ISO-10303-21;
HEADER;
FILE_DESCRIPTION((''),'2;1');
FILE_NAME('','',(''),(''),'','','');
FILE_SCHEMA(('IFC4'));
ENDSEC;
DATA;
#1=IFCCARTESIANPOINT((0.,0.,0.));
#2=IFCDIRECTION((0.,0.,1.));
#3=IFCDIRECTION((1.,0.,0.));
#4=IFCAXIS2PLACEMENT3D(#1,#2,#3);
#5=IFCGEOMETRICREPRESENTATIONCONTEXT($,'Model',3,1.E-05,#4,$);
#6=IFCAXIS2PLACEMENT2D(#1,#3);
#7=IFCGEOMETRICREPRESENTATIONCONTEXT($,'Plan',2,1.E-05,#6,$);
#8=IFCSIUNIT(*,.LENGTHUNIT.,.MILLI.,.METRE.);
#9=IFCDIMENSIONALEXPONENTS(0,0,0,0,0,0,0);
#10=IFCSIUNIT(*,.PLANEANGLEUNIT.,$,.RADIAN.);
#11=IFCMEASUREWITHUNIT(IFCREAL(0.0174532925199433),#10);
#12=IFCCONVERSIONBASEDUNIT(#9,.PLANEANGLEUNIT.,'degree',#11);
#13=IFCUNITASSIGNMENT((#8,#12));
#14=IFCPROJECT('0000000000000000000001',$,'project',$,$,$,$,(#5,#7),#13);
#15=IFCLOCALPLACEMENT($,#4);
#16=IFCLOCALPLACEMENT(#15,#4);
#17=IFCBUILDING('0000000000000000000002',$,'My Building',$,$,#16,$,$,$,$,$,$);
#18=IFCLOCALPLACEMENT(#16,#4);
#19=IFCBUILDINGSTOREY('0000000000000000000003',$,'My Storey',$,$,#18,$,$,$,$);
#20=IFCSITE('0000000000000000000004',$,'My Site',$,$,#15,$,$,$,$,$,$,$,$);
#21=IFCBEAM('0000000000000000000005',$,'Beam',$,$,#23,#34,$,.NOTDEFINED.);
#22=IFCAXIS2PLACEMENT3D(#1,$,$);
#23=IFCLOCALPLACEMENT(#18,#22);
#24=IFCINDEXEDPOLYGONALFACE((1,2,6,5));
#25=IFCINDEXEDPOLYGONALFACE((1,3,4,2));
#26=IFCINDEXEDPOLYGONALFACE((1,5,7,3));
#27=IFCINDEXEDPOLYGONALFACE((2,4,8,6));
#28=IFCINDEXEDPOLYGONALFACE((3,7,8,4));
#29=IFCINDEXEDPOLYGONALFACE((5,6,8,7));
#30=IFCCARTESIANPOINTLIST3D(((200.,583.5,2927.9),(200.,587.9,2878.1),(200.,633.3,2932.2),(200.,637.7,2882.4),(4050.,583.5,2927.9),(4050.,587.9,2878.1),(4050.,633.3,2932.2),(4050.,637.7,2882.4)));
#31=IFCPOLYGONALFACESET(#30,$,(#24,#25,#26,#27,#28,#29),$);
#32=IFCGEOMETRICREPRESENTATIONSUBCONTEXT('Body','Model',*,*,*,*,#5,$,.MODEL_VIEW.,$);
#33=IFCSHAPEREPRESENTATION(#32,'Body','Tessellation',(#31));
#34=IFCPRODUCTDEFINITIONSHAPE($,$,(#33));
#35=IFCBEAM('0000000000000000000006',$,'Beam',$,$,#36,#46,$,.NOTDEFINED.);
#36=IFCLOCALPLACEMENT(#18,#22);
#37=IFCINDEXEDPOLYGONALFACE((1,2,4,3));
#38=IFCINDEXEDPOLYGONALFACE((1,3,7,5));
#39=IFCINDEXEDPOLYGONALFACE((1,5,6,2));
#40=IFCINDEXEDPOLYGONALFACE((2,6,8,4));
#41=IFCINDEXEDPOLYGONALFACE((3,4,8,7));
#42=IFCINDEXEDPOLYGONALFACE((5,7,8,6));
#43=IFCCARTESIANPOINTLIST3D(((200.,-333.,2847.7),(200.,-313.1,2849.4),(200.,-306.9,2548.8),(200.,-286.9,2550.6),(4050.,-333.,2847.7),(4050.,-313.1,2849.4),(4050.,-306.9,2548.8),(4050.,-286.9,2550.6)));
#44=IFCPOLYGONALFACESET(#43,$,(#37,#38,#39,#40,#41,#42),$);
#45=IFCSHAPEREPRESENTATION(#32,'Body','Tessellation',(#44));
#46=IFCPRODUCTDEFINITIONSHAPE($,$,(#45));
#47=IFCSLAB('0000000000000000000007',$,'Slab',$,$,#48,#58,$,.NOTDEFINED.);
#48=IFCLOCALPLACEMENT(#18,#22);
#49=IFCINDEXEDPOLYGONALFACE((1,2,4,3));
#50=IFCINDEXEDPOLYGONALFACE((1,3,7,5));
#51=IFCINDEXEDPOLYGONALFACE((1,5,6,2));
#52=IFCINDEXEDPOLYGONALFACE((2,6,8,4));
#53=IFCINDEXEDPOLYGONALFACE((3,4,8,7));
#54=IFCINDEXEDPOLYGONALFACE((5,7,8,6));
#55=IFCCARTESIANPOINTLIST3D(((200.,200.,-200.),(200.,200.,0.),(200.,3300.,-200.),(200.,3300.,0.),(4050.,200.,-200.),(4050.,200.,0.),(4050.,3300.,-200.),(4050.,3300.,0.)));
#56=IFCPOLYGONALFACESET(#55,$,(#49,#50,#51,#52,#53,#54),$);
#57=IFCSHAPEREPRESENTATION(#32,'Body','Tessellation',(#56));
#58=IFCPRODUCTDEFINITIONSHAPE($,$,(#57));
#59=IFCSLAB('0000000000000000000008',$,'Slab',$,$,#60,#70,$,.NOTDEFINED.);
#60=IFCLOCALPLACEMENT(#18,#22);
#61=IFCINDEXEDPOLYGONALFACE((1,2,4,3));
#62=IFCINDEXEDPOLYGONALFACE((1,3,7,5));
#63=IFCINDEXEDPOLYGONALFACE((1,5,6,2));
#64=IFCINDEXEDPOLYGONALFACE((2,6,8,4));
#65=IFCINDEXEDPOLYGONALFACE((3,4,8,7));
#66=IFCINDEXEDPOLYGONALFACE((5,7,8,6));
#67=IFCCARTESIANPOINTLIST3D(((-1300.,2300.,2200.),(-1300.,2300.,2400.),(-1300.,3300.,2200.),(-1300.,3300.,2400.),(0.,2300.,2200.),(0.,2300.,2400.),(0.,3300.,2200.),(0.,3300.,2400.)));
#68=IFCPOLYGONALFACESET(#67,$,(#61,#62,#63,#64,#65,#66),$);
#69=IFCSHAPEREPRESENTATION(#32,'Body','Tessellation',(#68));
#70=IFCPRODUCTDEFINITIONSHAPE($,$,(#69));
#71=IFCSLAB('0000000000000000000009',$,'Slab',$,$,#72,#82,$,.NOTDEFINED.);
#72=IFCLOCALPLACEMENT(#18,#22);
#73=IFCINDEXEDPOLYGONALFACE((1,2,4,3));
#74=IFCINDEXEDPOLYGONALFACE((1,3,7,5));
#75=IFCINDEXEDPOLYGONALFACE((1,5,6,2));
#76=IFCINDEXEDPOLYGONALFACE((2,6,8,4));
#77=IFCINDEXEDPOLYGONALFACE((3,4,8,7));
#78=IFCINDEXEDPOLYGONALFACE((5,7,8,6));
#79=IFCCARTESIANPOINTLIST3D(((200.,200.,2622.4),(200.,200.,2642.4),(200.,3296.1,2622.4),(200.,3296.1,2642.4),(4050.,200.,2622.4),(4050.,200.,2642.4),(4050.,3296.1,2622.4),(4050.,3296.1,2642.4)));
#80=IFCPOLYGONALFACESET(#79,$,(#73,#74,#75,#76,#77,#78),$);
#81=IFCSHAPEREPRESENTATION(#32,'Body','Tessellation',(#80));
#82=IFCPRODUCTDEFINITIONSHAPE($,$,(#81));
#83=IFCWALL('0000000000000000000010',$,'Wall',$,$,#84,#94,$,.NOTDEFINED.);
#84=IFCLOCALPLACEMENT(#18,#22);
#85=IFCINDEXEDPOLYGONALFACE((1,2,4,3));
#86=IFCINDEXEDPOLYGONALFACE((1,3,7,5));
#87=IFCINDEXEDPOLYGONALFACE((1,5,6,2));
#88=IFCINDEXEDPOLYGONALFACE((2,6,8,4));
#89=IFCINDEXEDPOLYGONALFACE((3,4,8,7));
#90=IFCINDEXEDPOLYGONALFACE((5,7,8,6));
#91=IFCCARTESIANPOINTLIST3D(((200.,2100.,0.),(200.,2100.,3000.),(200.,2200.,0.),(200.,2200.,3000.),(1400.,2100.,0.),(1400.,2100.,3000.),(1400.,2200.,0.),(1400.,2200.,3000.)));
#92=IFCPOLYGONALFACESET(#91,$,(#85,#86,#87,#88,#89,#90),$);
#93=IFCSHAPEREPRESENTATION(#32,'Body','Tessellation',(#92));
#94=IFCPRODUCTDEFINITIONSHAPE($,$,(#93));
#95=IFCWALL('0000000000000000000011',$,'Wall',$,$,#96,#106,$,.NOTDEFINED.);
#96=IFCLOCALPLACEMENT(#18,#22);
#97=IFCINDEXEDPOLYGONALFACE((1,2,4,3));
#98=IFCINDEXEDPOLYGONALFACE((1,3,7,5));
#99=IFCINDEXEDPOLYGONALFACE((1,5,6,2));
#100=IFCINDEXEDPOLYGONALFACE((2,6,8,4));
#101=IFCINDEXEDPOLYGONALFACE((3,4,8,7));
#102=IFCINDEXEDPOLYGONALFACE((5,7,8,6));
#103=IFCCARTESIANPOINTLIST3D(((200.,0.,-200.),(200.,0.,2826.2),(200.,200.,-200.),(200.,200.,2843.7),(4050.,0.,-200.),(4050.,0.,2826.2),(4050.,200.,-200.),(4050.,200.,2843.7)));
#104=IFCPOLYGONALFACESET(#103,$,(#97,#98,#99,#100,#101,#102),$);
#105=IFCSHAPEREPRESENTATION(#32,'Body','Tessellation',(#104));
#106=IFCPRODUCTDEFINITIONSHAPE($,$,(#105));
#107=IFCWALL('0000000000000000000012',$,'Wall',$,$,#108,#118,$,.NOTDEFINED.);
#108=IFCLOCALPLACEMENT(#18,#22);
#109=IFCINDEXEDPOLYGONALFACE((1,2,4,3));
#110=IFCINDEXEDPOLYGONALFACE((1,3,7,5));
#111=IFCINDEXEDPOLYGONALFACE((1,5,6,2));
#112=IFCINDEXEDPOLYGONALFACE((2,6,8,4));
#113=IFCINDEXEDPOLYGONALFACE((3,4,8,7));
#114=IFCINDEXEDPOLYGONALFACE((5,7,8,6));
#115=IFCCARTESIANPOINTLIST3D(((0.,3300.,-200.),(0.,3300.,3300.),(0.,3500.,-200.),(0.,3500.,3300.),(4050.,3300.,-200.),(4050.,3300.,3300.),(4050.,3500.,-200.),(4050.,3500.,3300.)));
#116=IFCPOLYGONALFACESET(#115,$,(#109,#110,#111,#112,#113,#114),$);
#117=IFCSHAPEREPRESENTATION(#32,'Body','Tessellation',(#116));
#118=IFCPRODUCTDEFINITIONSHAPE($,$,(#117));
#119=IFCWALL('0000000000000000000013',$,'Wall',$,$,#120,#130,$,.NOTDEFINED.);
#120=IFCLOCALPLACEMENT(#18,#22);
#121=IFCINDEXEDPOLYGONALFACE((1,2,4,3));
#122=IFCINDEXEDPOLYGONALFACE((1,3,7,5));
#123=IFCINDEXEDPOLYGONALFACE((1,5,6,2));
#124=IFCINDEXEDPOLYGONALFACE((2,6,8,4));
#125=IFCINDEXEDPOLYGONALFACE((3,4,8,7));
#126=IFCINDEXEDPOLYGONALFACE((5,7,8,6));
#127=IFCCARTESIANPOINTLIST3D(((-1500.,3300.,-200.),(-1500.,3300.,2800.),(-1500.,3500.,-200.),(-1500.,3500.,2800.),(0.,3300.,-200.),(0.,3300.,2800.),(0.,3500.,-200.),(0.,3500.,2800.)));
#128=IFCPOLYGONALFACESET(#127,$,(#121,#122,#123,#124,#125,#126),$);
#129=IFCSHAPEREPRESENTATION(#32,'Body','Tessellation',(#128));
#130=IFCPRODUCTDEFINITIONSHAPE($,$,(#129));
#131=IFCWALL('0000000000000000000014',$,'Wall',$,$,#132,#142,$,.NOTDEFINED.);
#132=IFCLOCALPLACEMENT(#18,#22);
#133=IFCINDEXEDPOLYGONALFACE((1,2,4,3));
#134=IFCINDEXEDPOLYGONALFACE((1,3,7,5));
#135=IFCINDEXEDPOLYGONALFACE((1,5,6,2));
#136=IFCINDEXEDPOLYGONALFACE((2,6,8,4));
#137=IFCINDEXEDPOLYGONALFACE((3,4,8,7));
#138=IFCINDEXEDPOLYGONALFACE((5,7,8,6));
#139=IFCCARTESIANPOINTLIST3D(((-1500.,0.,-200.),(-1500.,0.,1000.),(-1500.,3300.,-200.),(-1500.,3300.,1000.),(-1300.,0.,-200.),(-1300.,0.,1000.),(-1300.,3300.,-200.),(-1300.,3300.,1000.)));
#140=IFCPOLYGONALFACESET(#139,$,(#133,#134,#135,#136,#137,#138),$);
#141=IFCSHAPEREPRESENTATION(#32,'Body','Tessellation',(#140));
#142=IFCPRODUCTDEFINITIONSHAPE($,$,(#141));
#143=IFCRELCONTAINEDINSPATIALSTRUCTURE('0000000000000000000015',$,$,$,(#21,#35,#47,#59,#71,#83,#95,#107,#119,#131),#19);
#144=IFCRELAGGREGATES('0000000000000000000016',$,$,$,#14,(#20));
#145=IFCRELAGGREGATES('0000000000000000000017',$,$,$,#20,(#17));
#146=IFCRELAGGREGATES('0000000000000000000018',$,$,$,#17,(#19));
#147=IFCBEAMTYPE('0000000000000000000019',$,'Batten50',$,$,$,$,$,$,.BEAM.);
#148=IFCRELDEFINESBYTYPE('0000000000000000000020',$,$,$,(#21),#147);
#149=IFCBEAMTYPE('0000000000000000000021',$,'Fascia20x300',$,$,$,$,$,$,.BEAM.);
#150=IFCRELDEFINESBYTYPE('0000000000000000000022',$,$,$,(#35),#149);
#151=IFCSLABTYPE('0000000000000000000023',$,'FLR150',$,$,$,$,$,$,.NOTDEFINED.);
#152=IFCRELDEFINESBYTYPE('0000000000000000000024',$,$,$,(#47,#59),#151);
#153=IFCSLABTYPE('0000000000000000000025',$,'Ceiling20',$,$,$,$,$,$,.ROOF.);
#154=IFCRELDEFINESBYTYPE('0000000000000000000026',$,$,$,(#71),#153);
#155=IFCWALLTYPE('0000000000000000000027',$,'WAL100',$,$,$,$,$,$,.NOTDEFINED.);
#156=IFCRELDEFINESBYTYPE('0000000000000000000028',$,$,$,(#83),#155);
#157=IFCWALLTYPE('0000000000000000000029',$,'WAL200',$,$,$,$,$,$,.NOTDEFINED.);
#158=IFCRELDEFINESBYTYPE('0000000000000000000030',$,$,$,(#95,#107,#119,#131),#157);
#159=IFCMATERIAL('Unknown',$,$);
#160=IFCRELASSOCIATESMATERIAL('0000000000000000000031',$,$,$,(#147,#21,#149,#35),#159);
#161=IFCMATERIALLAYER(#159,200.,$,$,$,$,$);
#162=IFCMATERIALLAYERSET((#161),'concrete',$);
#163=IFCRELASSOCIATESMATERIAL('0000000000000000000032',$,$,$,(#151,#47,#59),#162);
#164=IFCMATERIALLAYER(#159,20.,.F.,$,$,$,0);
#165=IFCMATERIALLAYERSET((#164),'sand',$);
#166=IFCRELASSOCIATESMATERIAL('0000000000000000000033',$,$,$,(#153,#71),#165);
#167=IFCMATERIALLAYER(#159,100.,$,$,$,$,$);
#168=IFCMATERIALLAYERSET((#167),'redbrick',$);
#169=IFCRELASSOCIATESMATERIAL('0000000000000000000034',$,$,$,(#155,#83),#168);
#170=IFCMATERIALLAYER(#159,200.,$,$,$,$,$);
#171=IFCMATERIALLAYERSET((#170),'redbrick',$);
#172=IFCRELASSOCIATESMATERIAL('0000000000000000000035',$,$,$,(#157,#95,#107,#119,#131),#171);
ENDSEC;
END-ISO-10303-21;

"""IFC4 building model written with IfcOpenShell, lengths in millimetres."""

from ifc_helpers import new_model, entity, si_unit, converted_unit, frame, frame_2d, origin_with_axes, place, context, subcontext, project, spatial, line, indexed_curve, rectangle, outline, extrude, clip, halfspace, material, layer, layer_set, layer_usage, material_profile, profile_set, profile_usage, type_object, element, save


model = new_model("IFC4")

# Units and contexts
model_context = context("Model", 3, precision=1e-05, world=origin_with_axes())
plan_context = context("Plan", 2, precision=1e-05, world=frame_2d((0.0, 0.0, 0.0), x_axis=(1.0, 0.0, 0.0)))
body_context = subcontext(model_context, "Body", "Model", "MODEL_VIEW")
ifc_project = project(units=[si_unit("LENGTHUNIT", "METRE", prefix="MILLI"), converted_unit("PLANEANGLEUNIT", "degree", entity("IfcReal", 0.0174532925199433), si_unit("PLANEANGLEUNIT", "RADIAN"), dimensions=[0, 0, 0, 0, 0, 0, 0])], contexts=[model_context, plan_context])

# Site, building, storey
site_placement = place(None, origin_with_axes())
site = spatial("IfcSite", under=ifc_project, at=site_placement, Name="My Site")
building_placement = place(site_placement, origin_with_axes())
building = spatial("IfcBuilding", under=site, at=building_placement, Name="My Building")
storey_placement = place(building_placement, origin_with_axes())
storey = spatial("IfcBuildingStorey", under=building, at=storey_placement, Name="My Storey")

# Shared definitions
ifc_material = material(Name="Unknown")

# Beams
ifc_material_profile_1 = material_profile(ifc_material, rectangle(XDim=50.0, YDim=50.0))
ifc_profile_set_1 = profile_set([ifc_material_profile_1], Name="blank")
beam_type_1 = type_object("IfcBeamType", Name="Batten50", PredefinedType="BEAM", material=ifc_profile_set_1)
ifc_profile_usage_1 = profile_usage(ifc_profile_set_1, cardinal=5)
beam_1_placement = place(storey_placement, frame((200.0, 610.6, 2905.1), z_axis=(1.0, 0.0, 0.0), x_axis=(0.0, 0.996195, 0.087156)))
element("IfcBeam", 1, at=beam_1_placement, inside=storey, type_object=beam_type_1, material=ifc_profile_usage_1, Name="Beam", PredefinedType="NOTDEFINED", context=body_context, shape_type="SweptSolid", body=[
    extrude(rectangle(XDim=50.0, YDim=50.0), origin_with_axes(), (0.0, 0.0, 1.0), 3850.0),
])
ifc_material_profile_2 = material_profile(ifc_material, rectangle(XDim=20.0, YDim=300.0))
ifc_profile_set_2 = profile_set([ifc_material_profile_2], Name="sand")
ifc_profile_usage_2 = profile_usage(ifc_profile_set_2, cardinal=5)
beam_type_2 = type_object("IfcBeamType", Name="Fascia20x300", PredefinedType="BEAM", material=ifc_profile_set_2)
beam_2_placement = place(storey_placement, frame((200.0, -310.0, 2699.1), z_axis=(1.0, 0.0, 0.0), x_axis=(0.0, 0.996195, 0.087156)))
element("IfcBeam", 2, at=beam_2_placement, inside=storey, type_object=beam_type_2, material=ifc_profile_usage_2, Name="Beam", PredefinedType="NOTDEFINED", context=body_context, shape_type="SweptSolid", body=[
    extrude(rectangle(XDim=20.0, YDim=300.0), origin_with_axes(), (0.0, 0.0, 1.0), 3850.0),
])

# Slabs
ifc_layer_1 = layer(ifc_material, 200.0)
ifc_layer_set_1 = layer_set([ifc_layer_1], Name="concrete")
ifc_layer_usage_1 = layer_usage(ifc_layer_set_1, "AXIS3", "POSITIVE", 0.0)
slab_type_1 = type_object("IfcSlabType", Name="FLR150", PredefinedType="NOTDEFINED", material=ifc_layer_set_1)
slab_1_placement = place(storey_placement, frame((200.0, 200.0, -200.0), z_axis=(0.0, 0.0, 1.0), x_axis=(1.0, 0.0, 0.0)))
element("IfcSlab", 3, at=slab_1_placement, inside=storey, type_object=slab_type_1, material=ifc_layer_usage_1, Name="Slab", PredefinedType="NOTDEFINED", context=body_context, shape_type="SweptSolid", body=[
    extrude(outline(indexed_curve([(0.0, 0.0), (3850.0, 0.0), (3850.0, 3100.0), (0.0, 3100.0)], segments=[line(3, 2), line(2, 1), line(1, 4), line(4, 3)], self_intersect=False)), None, (0.0, 0.0, 1.0), 200.0),
])
ifc_layer_usage_2 = layer_usage(ifc_layer_set_1, "AXIS3", "POSITIVE", 0.0)
slab_2_placement = place(storey_placement, frame((-1300.0, 2300.0, 2200.0), z_axis=(0.0, 0.0, 1.0), x_axis=(1.0, 0.0, 0.0)))
element("IfcSlab", 4, at=slab_2_placement, inside=storey, type_object=slab_type_1, material=ifc_layer_usage_2, Name="Slab", PredefinedType="NOTDEFINED", context=body_context, shape_type="SweptSolid", body=[
    extrude(outline(indexed_curve([(0.0, 0.0), (1300.0, 0.0), (1300.0, 1000.0), (0.0, 1000.0)], segments=[line(3, 2), line(2, 1), line(1, 4), line(4, 3)], self_intersect=False)), None, (0.0, 0.0, 1.0), 200.0),
])
ifc_layer_2 = layer(ifc_material, 20.0, ventilated=False, Priority=0)
ifc_layer_set_2 = layer_set([ifc_layer_2], Name="sand")
ifc_layer_usage_3 = layer_usage(ifc_layer_set_2, "AXIS3", "POSITIVE", 0.0)
slab_type_2 = type_object("IfcSlabType", Name="Ceiling20", PredefinedType="ROOF", material=ifc_layer_set_2)
slab_3_placement = place(storey_placement, frame((200.0, 200.0, 2622.4), z_axis=(0.0, 0.0, 1.0), x_axis=(1.0, 0.0, 0.0)))
element("IfcSlab", 5, at=slab_3_placement, inside=storey, type_object=slab_type_2, material=ifc_layer_usage_3, Name="Slab", PredefinedType="NOTDEFINED", context=body_context, shape_type="SweptSolid", body=[
    extrude(outline(indexed_curve([(0.0, 0.0), (3850.0, 0.0), (3850.0, 3096.1), (0.0, 3096.1)], segments=[line(3, 2), line(2, 1), line(1, 4), line(4, 3)], self_intersect=False)), None, (0.0, 0.0, 1.0), 20.0),
])

# Walls
ifc_layer_3 = layer(ifc_material, 100.0)
ifc_layer_set_3 = layer_set([ifc_layer_3], Name="redbrick")
ifc_layer_usage_4 = layer_usage(ifc_layer_set_3, "AXIS2", "POSITIVE", 0.0)
wall_type_1 = type_object("IfcWallType", Name="WAL100", PredefinedType="NOTDEFINED", material=ifc_layer_set_3)
wall_1_placement = place(storey_placement, frame((200.0, 2100.0, 0.0), z_axis=(0.0, 0.0, 1.0), x_axis=(1.0, 0.0, 0.0)))
element("IfcWall", 6, at=wall_1_placement, inside=storey, type_object=wall_type_1, material=ifc_layer_usage_4, Name="Wall", PredefinedType="NOTDEFINED", context=body_context, shape_type="SweptSolid", body=[
    extrude(outline(indexed_curve([(0.0, 0.0), (0.0, 100.0), (1200.0, 100.0), (1200.0, 0.0), (0.0, 0.0)], self_intersect=False)), origin_with_axes(), (0.0, 0.0, 1.0), 3000.0),
])
ifc_layer_4 = layer(ifc_material, 200.0)
ifc_layer_set_4 = layer_set([ifc_layer_4], Name="redbrick")
ifc_layer_usage_5 = layer_usage(ifc_layer_set_4, "AXIS2", "POSITIVE", 0.0)
wall_type_2 = type_object("IfcWallType", Name="WAL200", PredefinedType="NOTDEFINED", material=ifc_layer_set_4)
wall_2_placement = place(storey_placement, frame((200.0, 0.0, -200.0), z_axis=(0.0, 0.0, 1.0), x_axis=(1.0, 0.0, 0.0)))
element("IfcWall", 7, at=wall_2_placement, inside=storey, type_object=wall_type_2, material=ifc_layer_usage_5, Name="Wall", PredefinedType="NOTDEFINED", context=body_context, shape_type="Clipping", body=[
    clip(extrude(outline(indexed_curve([(0.0, 0.0), (0.0, 200.0), (3850.0, 200.0), (3850.0, 0.0), (0.0, 0.0)], self_intersect=False)), origin_with_axes(), (0.0, 0.0, 1.0), 3043.7), halfspace(frame((0.0, 200.0, 3043.7), z_axis=(0.0, -0.087156, 0.996195), x_axis=(1.0, 0.0, 0.0)), False)),
])
ifc_layer_usage_6 = layer_usage(ifc_layer_set_4, "AXIS2", "POSITIVE", 0.0)
wall_3_placement = place(storey_placement, frame((4050.0, 3500.0, -200.0), z_axis=(0.0, 0.0, 1.0), x_axis=(-1.0, 0.0, 0.0)))
element("IfcWall", 8, at=wall_3_placement, inside=storey, type_object=wall_type_2, material=ifc_layer_usage_6, Name="Wall", PredefinedType="NOTDEFINED", context=body_context, shape_type="SweptSolid", body=[
    extrude(outline(indexed_curve([(0.0, 0.0), (0.0, 200.0), (4050.0, 200.0), (4050.0, 0.0), (0.0, 0.0)], self_intersect=False)), origin_with_axes(), (0.0, 0.0, 1.0), 3500.0),
])
ifc_layer_usage_7 = layer_usage(ifc_layer_set_4, "AXIS2", "POSITIVE", 0.0)
wall_4_placement = place(storey_placement, frame((0.0, 3500.0, -200.0), z_axis=(0.0, 0.0, 1.0), x_axis=(-1.0, 0.0, 0.0)))
element("IfcWall", 9, at=wall_4_placement, inside=storey, type_object=wall_type_2, material=ifc_layer_usage_7, Name="Wall", PredefinedType="NOTDEFINED", context=body_context, shape_type="SweptSolid", body=[
    extrude(outline(indexed_curve([(0.0, 0.0), (0.0, 200.0), (1500.0, 200.0), (1500.0, 0.0), (0.0, 0.0)], self_intersect=False)), origin_with_axes(), (0.0, 0.0, 1.0), 3000.0),
])
ifc_layer_usage_8 = layer_usage(ifc_layer_set_4, "AXIS2", "POSITIVE", 0.0)
wall_5_placement = place(storey_placement, frame((-1500.0, 3300.0, -200.0), z_axis=(0.0, 0.0, 1.0), x_axis=(0.0, -1.0, 0.0)))
element("IfcWall", 10, at=wall_5_placement, inside=storey, type_object=wall_type_2, material=ifc_layer_usage_8, Name="Wall", PredefinedType="NOTDEFINED", context=body_context, shape_type="SweptSolid", body=[
    extrude(outline(indexed_curve([(0.0, 0.0), (0.0, 200.0), (3300.0, 200.0), (3300.0, 0.0), (0.0, 0.0)], self_intersect=False)), origin_with_axes(), (0.0, 0.0, 1.0), 1200.0),
])

save(model, "model.ifc")
